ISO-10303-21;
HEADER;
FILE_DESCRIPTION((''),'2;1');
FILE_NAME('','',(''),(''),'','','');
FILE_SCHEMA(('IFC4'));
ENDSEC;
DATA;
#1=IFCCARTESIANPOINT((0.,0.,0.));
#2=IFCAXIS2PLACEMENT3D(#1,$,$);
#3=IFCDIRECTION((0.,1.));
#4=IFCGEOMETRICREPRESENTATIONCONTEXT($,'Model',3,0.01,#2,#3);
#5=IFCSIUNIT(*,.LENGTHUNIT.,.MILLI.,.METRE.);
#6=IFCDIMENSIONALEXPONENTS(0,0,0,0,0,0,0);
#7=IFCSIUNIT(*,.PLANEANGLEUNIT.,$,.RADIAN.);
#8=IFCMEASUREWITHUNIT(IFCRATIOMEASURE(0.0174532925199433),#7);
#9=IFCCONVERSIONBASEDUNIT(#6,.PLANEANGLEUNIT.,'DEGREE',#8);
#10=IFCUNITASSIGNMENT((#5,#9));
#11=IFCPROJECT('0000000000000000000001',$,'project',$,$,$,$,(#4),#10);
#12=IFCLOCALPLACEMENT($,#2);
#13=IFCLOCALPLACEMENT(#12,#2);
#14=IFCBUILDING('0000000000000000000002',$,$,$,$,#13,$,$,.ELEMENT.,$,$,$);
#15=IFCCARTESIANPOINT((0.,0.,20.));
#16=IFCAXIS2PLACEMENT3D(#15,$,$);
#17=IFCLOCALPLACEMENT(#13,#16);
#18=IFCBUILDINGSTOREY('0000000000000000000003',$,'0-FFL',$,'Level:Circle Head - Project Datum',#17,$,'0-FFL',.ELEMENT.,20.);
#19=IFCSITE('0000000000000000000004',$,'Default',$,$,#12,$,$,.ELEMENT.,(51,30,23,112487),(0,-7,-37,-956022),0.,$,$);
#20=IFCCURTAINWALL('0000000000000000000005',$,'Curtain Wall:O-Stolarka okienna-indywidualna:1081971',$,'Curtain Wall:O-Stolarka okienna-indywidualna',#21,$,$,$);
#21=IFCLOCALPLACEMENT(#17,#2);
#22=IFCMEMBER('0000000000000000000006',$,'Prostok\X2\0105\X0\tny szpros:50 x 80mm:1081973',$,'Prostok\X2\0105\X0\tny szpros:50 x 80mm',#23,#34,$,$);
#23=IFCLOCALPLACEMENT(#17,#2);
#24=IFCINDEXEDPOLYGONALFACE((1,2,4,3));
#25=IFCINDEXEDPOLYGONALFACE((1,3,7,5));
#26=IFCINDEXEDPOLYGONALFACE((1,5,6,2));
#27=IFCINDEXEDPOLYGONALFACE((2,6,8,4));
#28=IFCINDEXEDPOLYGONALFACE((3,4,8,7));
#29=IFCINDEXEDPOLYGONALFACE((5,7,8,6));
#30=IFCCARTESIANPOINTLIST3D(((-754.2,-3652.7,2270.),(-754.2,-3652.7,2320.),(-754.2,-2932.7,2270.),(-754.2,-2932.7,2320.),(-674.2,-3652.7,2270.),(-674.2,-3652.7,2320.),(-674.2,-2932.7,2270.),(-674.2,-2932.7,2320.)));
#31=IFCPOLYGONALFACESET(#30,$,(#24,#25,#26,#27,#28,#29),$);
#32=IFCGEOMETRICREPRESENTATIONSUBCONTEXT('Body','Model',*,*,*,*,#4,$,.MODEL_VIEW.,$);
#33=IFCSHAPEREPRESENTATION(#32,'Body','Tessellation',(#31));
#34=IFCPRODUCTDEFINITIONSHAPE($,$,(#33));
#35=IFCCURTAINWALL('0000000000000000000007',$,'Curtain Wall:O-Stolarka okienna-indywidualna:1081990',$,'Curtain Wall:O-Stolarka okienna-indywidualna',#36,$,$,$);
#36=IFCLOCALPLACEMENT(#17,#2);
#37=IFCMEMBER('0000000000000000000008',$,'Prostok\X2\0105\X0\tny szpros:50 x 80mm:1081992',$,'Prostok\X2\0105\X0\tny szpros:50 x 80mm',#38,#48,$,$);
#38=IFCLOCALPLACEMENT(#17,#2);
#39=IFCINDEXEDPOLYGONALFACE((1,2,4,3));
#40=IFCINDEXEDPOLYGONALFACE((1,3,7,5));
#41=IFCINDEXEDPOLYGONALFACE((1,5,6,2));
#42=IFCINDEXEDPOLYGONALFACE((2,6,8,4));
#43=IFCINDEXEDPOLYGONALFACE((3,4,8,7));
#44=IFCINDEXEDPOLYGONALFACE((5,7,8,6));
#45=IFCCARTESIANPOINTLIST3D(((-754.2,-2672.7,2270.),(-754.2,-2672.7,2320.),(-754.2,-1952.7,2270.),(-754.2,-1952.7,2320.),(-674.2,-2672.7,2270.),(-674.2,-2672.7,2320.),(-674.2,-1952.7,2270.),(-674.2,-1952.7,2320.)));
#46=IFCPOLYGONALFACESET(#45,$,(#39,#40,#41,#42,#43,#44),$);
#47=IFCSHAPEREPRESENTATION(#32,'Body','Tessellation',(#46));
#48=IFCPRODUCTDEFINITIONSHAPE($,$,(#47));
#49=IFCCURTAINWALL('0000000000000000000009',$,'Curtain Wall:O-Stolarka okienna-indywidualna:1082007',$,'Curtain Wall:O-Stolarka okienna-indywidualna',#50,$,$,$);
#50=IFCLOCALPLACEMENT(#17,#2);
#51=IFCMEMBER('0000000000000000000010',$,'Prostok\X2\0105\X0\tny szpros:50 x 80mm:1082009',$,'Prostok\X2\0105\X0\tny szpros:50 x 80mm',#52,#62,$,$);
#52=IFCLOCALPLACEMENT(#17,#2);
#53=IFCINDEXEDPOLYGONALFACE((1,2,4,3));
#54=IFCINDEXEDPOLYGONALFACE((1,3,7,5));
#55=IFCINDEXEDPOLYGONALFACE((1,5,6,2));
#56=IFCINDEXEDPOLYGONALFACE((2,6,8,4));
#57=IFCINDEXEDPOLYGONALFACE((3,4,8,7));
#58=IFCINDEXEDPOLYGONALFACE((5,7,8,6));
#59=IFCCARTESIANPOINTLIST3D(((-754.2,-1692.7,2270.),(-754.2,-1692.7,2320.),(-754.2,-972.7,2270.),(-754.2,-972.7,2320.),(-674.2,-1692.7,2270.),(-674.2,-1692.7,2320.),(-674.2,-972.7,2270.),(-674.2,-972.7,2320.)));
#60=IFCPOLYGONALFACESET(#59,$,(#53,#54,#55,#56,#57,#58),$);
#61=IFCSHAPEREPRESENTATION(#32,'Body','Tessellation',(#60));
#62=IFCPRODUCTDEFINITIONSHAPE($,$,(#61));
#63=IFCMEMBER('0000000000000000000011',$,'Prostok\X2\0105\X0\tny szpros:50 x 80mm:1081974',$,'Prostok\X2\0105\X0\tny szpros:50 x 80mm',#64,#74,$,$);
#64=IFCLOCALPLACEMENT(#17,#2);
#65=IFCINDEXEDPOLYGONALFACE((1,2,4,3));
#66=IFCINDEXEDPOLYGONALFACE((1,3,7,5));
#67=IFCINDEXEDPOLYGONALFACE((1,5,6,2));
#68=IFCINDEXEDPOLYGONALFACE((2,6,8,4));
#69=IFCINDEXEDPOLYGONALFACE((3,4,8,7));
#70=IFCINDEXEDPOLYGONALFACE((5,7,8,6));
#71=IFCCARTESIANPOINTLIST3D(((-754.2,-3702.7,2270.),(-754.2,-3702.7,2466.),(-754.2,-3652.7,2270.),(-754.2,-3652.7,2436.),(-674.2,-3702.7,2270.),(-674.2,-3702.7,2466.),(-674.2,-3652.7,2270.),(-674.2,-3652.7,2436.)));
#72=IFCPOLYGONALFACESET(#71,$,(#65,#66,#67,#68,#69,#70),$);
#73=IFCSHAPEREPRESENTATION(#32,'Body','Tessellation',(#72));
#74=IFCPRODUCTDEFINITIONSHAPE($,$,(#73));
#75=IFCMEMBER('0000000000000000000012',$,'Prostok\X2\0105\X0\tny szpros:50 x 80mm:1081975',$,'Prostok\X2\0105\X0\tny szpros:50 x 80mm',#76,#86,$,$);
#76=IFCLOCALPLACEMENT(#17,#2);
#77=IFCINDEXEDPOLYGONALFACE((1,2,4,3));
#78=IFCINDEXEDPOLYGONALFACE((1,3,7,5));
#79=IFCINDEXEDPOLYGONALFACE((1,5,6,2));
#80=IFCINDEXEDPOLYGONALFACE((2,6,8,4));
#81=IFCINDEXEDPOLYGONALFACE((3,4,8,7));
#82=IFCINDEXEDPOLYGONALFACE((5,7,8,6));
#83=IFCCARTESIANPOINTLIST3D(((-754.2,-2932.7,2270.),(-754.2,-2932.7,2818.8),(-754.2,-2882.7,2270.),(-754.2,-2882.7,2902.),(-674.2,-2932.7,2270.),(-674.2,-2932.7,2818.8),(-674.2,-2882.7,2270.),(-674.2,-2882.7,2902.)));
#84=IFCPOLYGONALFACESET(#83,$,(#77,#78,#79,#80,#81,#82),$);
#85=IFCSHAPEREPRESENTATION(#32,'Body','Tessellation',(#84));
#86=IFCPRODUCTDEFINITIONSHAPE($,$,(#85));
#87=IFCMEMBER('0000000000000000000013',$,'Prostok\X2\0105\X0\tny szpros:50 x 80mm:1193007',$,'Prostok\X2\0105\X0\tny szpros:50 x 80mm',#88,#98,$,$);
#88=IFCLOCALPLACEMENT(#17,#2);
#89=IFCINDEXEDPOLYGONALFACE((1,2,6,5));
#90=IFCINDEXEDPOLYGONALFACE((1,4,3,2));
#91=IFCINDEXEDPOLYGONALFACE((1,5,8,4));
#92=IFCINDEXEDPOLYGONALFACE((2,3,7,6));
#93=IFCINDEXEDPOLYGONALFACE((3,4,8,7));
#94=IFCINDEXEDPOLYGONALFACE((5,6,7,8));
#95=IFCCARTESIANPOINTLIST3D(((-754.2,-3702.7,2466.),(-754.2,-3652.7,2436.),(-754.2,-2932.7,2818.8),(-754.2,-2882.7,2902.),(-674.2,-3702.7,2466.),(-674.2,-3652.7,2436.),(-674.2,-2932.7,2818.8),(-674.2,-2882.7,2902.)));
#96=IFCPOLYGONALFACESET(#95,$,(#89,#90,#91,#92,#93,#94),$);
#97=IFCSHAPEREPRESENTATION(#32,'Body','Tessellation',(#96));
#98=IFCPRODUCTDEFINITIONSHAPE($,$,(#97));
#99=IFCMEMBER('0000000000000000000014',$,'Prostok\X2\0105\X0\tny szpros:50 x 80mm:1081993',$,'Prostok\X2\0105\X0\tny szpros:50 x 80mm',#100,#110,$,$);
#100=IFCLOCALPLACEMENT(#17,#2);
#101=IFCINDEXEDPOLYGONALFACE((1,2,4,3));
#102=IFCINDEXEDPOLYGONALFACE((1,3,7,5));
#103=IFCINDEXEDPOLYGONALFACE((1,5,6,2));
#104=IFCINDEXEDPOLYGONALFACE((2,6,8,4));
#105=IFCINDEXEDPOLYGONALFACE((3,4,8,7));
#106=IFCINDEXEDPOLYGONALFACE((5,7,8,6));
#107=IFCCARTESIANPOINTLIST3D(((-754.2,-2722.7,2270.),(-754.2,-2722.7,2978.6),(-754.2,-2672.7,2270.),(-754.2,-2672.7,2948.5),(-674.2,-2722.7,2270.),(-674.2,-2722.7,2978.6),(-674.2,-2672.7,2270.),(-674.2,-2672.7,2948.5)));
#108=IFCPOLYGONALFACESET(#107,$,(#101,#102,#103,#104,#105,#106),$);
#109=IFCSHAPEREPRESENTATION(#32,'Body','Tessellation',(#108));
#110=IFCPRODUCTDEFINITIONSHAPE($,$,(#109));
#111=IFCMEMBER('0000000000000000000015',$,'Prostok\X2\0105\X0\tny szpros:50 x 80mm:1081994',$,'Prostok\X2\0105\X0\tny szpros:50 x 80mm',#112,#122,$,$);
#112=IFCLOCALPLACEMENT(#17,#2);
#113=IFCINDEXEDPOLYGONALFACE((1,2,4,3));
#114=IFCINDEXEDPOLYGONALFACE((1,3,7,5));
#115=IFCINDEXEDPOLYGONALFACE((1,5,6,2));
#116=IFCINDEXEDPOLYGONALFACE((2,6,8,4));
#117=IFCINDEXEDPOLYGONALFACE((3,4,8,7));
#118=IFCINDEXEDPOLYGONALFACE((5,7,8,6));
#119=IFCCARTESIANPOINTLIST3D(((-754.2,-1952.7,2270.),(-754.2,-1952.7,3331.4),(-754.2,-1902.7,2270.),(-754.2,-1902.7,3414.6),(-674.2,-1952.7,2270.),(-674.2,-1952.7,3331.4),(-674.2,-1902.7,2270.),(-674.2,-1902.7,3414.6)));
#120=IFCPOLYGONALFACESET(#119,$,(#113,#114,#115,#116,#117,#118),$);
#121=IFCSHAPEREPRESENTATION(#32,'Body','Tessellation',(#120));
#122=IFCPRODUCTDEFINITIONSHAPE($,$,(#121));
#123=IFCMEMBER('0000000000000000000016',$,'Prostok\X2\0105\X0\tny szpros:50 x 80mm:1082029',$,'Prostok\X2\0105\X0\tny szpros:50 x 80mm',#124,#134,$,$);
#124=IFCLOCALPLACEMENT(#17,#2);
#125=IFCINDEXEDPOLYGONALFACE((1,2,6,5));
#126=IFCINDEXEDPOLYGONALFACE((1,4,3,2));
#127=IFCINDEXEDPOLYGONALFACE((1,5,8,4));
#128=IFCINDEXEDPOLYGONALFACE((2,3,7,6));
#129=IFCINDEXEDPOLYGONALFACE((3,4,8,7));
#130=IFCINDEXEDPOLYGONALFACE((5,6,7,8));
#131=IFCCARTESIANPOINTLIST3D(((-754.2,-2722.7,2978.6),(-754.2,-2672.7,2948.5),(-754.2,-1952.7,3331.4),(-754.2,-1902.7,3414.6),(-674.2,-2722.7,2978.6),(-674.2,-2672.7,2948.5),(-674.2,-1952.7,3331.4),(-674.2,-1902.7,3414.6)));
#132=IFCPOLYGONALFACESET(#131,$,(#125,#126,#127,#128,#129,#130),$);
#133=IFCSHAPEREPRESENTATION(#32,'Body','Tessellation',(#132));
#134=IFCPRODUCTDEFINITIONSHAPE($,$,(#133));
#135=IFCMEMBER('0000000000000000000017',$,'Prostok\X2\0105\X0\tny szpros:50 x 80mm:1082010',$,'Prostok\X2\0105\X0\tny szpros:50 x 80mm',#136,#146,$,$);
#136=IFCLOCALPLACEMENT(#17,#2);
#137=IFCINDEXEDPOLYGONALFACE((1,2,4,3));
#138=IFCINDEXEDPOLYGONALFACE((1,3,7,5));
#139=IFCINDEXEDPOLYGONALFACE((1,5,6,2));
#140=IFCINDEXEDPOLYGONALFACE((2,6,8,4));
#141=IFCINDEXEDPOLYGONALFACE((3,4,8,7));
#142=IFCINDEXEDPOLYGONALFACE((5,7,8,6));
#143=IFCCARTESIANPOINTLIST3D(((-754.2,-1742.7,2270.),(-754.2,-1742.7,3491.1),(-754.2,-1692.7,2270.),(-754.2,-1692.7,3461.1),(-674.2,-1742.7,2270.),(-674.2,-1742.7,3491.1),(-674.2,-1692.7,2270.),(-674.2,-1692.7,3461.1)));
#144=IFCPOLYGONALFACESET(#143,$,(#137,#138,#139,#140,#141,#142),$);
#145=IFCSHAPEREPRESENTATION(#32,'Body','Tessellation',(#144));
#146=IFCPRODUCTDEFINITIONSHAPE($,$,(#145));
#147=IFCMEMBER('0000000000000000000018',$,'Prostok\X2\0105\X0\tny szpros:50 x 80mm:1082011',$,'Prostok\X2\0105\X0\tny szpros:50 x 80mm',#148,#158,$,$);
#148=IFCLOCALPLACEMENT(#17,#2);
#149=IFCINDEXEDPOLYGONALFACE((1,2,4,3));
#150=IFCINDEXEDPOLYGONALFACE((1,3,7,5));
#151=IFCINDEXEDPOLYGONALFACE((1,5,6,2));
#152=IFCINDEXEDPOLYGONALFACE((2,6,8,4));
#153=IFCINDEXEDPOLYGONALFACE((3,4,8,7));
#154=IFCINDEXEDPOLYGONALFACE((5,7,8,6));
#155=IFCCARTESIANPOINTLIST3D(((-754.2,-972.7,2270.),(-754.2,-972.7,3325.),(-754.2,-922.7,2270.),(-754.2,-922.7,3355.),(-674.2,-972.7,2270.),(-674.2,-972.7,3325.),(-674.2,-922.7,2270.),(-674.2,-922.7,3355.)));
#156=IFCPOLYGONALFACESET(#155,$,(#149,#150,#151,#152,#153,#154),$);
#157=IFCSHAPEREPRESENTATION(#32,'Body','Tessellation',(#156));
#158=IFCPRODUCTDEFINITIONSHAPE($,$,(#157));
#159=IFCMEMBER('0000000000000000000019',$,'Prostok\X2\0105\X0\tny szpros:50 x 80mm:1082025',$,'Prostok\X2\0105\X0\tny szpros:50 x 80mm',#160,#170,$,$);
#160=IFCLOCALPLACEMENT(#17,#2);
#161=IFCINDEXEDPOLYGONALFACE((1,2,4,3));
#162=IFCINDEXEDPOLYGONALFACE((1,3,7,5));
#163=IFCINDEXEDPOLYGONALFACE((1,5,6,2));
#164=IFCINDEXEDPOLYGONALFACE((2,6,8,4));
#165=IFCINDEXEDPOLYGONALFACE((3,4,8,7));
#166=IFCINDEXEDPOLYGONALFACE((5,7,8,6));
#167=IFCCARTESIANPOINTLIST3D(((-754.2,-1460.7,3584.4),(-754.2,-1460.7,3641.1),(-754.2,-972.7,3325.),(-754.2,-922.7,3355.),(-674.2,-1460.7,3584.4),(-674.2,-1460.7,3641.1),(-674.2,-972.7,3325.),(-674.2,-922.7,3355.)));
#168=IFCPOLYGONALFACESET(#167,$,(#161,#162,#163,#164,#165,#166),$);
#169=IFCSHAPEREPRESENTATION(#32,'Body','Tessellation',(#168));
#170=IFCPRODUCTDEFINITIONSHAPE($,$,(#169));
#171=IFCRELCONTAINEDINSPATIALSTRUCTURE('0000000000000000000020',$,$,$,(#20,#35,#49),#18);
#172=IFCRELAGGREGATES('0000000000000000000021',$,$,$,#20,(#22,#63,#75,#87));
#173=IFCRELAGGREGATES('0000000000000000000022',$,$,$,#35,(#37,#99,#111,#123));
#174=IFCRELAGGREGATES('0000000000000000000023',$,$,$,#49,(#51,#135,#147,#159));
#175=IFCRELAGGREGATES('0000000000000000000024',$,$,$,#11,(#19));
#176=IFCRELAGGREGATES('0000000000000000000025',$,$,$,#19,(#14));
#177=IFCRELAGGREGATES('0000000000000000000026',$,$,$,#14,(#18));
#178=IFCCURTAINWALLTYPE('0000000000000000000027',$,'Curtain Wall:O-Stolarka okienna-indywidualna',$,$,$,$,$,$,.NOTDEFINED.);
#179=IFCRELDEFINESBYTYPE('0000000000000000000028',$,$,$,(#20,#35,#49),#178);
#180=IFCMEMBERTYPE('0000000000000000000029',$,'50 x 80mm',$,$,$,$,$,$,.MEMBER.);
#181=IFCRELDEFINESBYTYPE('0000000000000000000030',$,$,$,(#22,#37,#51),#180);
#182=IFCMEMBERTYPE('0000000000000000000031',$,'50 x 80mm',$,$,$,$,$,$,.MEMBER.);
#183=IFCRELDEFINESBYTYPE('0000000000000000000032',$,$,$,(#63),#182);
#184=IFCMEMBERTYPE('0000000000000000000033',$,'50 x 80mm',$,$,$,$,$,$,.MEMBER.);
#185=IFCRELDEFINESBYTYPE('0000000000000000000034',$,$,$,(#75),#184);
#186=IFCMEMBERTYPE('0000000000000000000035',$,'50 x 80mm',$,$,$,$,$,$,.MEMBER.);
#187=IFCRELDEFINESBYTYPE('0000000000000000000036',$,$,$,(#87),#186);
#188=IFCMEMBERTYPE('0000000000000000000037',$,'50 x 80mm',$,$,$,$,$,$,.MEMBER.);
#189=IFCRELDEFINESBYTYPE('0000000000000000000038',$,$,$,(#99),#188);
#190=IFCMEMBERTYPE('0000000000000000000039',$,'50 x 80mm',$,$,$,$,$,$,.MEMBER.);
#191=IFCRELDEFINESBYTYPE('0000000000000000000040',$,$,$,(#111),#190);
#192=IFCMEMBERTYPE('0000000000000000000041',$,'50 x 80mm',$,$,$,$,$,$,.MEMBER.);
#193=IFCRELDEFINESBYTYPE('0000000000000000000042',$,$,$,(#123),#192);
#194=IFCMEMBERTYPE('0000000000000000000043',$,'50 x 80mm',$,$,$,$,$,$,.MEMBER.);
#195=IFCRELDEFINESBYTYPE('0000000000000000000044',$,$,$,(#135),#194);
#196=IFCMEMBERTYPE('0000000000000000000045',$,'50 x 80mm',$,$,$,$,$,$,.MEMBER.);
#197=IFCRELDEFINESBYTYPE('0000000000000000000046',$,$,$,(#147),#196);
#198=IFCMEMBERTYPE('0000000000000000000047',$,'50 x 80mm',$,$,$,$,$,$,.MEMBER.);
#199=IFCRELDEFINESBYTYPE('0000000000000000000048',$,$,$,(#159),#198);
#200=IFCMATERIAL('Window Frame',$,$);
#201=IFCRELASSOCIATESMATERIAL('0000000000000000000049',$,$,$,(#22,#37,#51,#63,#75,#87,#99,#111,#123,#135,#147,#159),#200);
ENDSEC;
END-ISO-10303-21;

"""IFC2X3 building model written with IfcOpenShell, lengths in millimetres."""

from ifc_helpers import new_model, entity, si_unit, converted_unit, direction, frame, origin, origin_2d_with_axis, place, context, subcontext, project, spatial, rectangle, extrude, clip, halfspace, source, transform, mapped, material, type_object, type_shapes, element, aggregate, save


model = new_model("IFC2X3")

# Units and contexts
model_context = context("Model", 3, precision=0.01, world=origin(), true_north=direction((0.0, 1.0)))
body_context = subcontext(model_context, "Body", "Model", "MODEL_VIEW")
ifc_project = project(units=[si_unit("LENGTHUNIT", "METRE", prefix="MILLI"), converted_unit("PLANEANGLEUNIT", "DEGREE", entity("IfcRatioMeasure", 0.0174532925199433), si_unit("PLANEANGLEUNIT", "RADIAN"), dimensions=[0, 0, 0, 0, 0, 0, 0])], contexts=[model_context])

# Site, building, storey
site_placement = place(None, origin())
site = spatial("IfcSite", under=ifc_project, at=site_placement, Name="Default", CompositionType="ELEMENT", RefLatitude=(51, 30, 23, 112487), RefLongitude=(0, -7, -37, -956022), RefElevation=0.0)
building_placement = place(site_placement, origin())
building = spatial("IfcBuilding", under=site, at=building_placement, CompositionType="ELEMENT")
storey_placement = place(building_placement, frame((0.0, 0.0, 20.0)))
storey = spatial("IfcBuildingStorey", under=building, at=storey_placement, Name="0-FFL", ObjectType="Level:Circle Head - Project Datum", LongName="0-FFL", CompositionType="ELEMENT", Elevation=20.0)

# Curtain walls, members
curtain_wall_type = type_object("IfcCurtainWallType", Name="Curtain Wall:O-Stolarka okienna-indywidualna", PredefinedType="NOTDEFINED")
curtain_wall_1_placement = place(storey_placement, frame((0.0, 0.0, -20.0)))
curtain_wall_1 = element("IfcCurtainWall", 1, at=curtain_wall_1_placement, inside=storey, type_object=curtain_wall_type, Name="Curtain Wall:O-Stolarka okienna-indywidualna:1081971", ObjectType="Curtain Wall:O-Stolarka okienna-indywidualna")
ifc_material_1 = material(Name="Window Frame")
member_type_1 = type_object("IfcMemberType", Name="50 x 80mm", PredefinedType="MEMBER")
shared_shape_1 = source(origin(), body_context, "Body", "SweptSolid", [
    extrude(rectangle(XDim=80.0, YDim=50.0, at=origin_2d_with_axis()), frame((-25.0, 0.0, -720.0), z_axis=(0.0, 0.0, 1.0), x_axis=(0.0, -1.0, 0.0)), (0.0, 0.0, 1.0), 720.0),
])
type_shapes(member_type_1, [shared_shape_1])
member_1_placement = place(storey_placement, frame((-714.2, -2932.7, 2270.0), z_axis=(0.0, 1.0, 0.0), x_axis=(0.0, 0.0, -1.0)))
member_1 = element("IfcMember", 2, at=member_1_placement, type_object=member_type_1, material=ifc_material_1, Name="Prostokątny szpros:50 x 80mm:1081973", ObjectType="Prostokątny szpros:50 x 80mm", context=body_context, shape_type="MappedRepresentation", body=[
    mapped(shared_shape_1, transform((0.0, 0.0, 0.0), scale=1.0)),
])
curtain_wall_2_placement = place(storey_placement, frame((0.0, 0.0, -20.0)))
curtain_wall_2 = element("IfcCurtainWall", 3, at=curtain_wall_2_placement, inside=storey, type_object=curtain_wall_type, Name="Curtain Wall:O-Stolarka okienna-indywidualna:1081990", ObjectType="Curtain Wall:O-Stolarka okienna-indywidualna")
member_2_placement = place(storey_placement, frame((-714.2, -1952.7, 2270.0), z_axis=(0.0, 1.0, 0.0), x_axis=(0.0, 0.0, -1.0)))
member_2 = element("IfcMember", 4, at=member_2_placement, type_object=member_type_1, material=ifc_material_1, Name="Prostokątny szpros:50 x 80mm:1081992", ObjectType="Prostokątny szpros:50 x 80mm", context=body_context, shape_type="MappedRepresentation", body=[
    mapped(shared_shape_1, transform((0.0, 0.0, 0.0), scale=1.0)),
])
curtain_wall_3_placement = place(storey_placement, frame((0.0, 0.0, -20.0)))
curtain_wall_3 = element("IfcCurtainWall", 5, at=curtain_wall_3_placement, inside=storey, type_object=curtain_wall_type, Name="Curtain Wall:O-Stolarka okienna-indywidualna:1082007", ObjectType="Curtain Wall:O-Stolarka okienna-indywidualna")
member_3_placement = place(storey_placement, frame((-714.2, -972.7, 2270.0), z_axis=(0.0, 1.0, 0.0), x_axis=(0.0, 0.0, -1.0)))
member_3 = element("IfcMember", 6, at=member_3_placement, type_object=member_type_1, material=ifc_material_1, Name="Prostokątny szpros:50 x 80mm:1082009", ObjectType="Prostokątny szpros:50 x 80mm", context=body_context, shape_type="MappedRepresentation", body=[
    mapped(shared_shape_1, transform((0.0, 0.0, 0.0), scale=1.0)),
])

# Members
member_type_2 = type_object("IfcMemberType", Name="50 x 80mm", PredefinedType="MEMBER")
shared_shape_2 = source(origin(), body_context, "Body", "Clipping", [
    clip(extrude(rectangle(XDim=80.0, YDim=50.0, at=origin_2d_with_axis()), frame((-25.0, 0.0, -196.0), z_axis=(0.0, 0.0, 1.0), x_axis=(0.0, -1.0, 0.0)), (0.0, 0.0, 1.0), 196.0), halfspace(frame((0.0, -304.8, -196.0), z_axis=(-0.515038, 0.0, -0.857167), x_axis=(-0.857167, 0.0, 0.515038)), False)),
])
type_shapes(member_type_2, [shared_shape_2])
member_4_placement = place(storey_placement, frame((-714.2, -3702.7, 2270.0), z_axis=(0.0, 0.0, -1.0), x_axis=(0.0, -1.0, 0.0)))
member_4 = element("IfcMember", 7, at=member_4_placement, type_object=member_type_2, material=ifc_material_1, Name="Prostokątny szpros:50 x 80mm:1081974", ObjectType="Prostokątny szpros:50 x 80mm", context=body_context, shape_type="MappedRepresentation", body=[
    mapped(shared_shape_2, transform((0.0, 0.0, 0.0), scale=1.0)),
])
member_type_3 = type_object("IfcMemberType", Name="50 x 80mm", PredefinedType="MEMBER")
shared_shape_3 = source(origin(), body_context, "Body", "Clipping", [
    clip(extrude(rectangle(XDim=80.0, YDim=50.0, at=origin_2d_with_axis()), frame((-25.0, 0.0, -632.0), z_axis=(0.0, 0.0, 1.0), x_axis=(0.0, -1.0, 0.0)), (0.0, 0.0, 1.0), 632.0), halfspace(frame((0.0, -304.8, 0.0), z_axis=(-0.857167, 0.0, 0.515038), x_axis=(-0.515038, 0.0, -0.857167)), False)),
])
type_shapes(member_type_3, [shared_shape_3])
member_5_placement = place(storey_placement, frame((-714.2, -2882.7, 2902.0), z_axis=(0.0, 0.0, 1.0), x_axis=(0.0, 1.0, 0.0)))
member_5 = element("IfcMember", 8, at=member_5_placement, type_object=member_type_3, material=ifc_material_1, Name="Prostokątny szpros:50 x 80mm:1081975", ObjectType="Prostokątny szpros:50 x 80mm", context=body_context, shape_type="MappedRepresentation", body=[
    mapped(shared_shape_3, transform((0.0, 0.0, 0.0), scale=1.0)),
])
member_type_4 = type_object("IfcMemberType", Name="50 x 80mm", PredefinedType="MEMBER")
shared_shape_4 = source(origin(), body_context, "Body", "Clipping", [
    clip(clip(extrude(rectangle(XDim=80.0, YDim=50.0, at=origin_2d_with_axis()), frame((-25.0, 0.0, -928.7), z_axis=(0.0, 0.0, 1.0), x_axis=(0.0, -1.0, 0.0)), (0.0, 0.0, 1.0), 928.7), halfspace(frame((0.0, -304.8, -928.7), z_axis=(-0.857167, 0.0, -0.515038), x_axis=(-0.515038, 0.0, 0.857167)), False)), halfspace(frame((0.0, -304.8, 0.0), z_axis=(-0.515038, 0.0, 0.857167), x_axis=(-0.857167, 0.0, -0.515038)), False)),
])
type_shapes(member_type_4, [shared_shape_4])
member_6_placement = place(storey_placement, frame((-714.2, -3702.7, 2466.0), z_axis=(0.0, -0.882948, -0.469472), x_axis=(0.0, -0.469472, 0.882948)))
member_6 = element("IfcMember", 9, at=member_6_placement, type_object=member_type_4, material=ifc_material_1, Name="Prostokątny szpros:50 x 80mm:1193007", ObjectType="Prostokątny szpros:50 x 80mm", context=body_context, shape_type="MappedRepresentation", body=[
    mapped(shared_shape_4, transform((0.0, 0.0, 0.0), scale=1.0)),
])
member_type_5 = type_object("IfcMemberType", Name="50 x 80mm", PredefinedType="MEMBER")
shared_shape_5 = source(origin(), body_context, "Body", "Clipping", [
    clip(extrude(rectangle(XDim=80.0, YDim=50.0, at=origin_2d_with_axis()), frame((-25.0, 0.0, -708.6), z_axis=(0.0, 0.0, 1.0), x_axis=(0.0, -1.0, 0.0)), (0.0, 0.0, 1.0), 708.6), halfspace(frame((0.0, -304.8, -708.6), z_axis=(-0.515038, 0.0, -0.857167), x_axis=(-0.857167, 0.0, 0.515038)), False)),
])
type_shapes(member_type_5, [shared_shape_5])
member_7_placement = place(storey_placement, frame((-714.2, -2722.7, 2270.0), z_axis=(0.0, 0.0, -1.0), x_axis=(0.0, -1.0, 0.0)))
member_7 = element("IfcMember", 10, at=member_7_placement, type_object=member_type_5, material=ifc_material_1, Name="Prostokątny szpros:50 x 80mm:1081993", ObjectType="Prostokątny szpros:50 x 80mm", context=body_context, shape_type="MappedRepresentation", body=[
    mapped(shared_shape_5, transform((0.0, 0.0, 0.0), scale=1.0)),
])
member_type_6 = type_object("IfcMemberType", Name="50 x 80mm", PredefinedType="MEMBER")
shared_shape_6 = source(origin(), body_context, "Body", "Clipping", [
    clip(extrude(rectangle(XDim=80.0, YDim=50.0, at=origin_2d_with_axis()), frame((-25.0, 0.0, -1144.6), z_axis=(0.0, 0.0, 1.0), x_axis=(0.0, -1.0, 0.0)), (0.0, 0.0, 1.0), 1144.6), halfspace(frame((0.0, -304.8, 0.0), z_axis=(-0.857167, 0.0, 0.515038), x_axis=(-0.515038, 0.0, -0.857167)), False)),
])
type_shapes(member_type_6, [shared_shape_6])
member_8_placement = place(storey_placement, frame((-714.2, -1902.7, 3414.6), z_axis=(0.0, 0.0, 1.0), x_axis=(0.0, 1.0, 0.0)))
member_8 = element("IfcMember", 11, at=member_8_placement, type_object=member_type_6, material=ifc_material_1, Name="Prostokątny szpros:50 x 80mm:1081994", ObjectType="Prostokątny szpros:50 x 80mm", context=body_context, shape_type="MappedRepresentation", body=[
    mapped(shared_shape_6, transform((0.0, 0.0, 0.0), scale=1.0)),
])
member_type_7 = type_object("IfcMemberType", Name="50 x 80mm", PredefinedType="MEMBER")
shared_shape_7 = source(origin(), body_context, "Body", "Clipping", [
    clip(clip(extrude(rectangle(XDim=80.0, YDim=50.0, at=origin_2d_with_axis()), frame((-25.0, 0.0, -928.7), z_axis=(0.0, 0.0, 1.0), x_axis=(0.0, -1.0, 0.0)), (0.0, 0.0, 1.0), 928.7), halfspace(frame((0.0, -304.8, -928.7), z_axis=(-0.857167, 0.0, -0.515038), x_axis=(-0.515038, 0.0, 0.857167)), False)), halfspace(frame((0.0, -304.8, 0.0), z_axis=(-0.515038, 0.0, 0.857167), x_axis=(-0.857167, 0.0, -0.515038)), False)),
])
type_shapes(member_type_7, [shared_shape_7])
member_9_placement = place(storey_placement, frame((-714.2, -2722.7, 2978.6), z_axis=(0.0, -0.882948, -0.469472), x_axis=(0.0, -0.469472, 0.882948)))
member_9 = element("IfcMember", 12, at=member_9_placement, type_object=member_type_7, material=ifc_material_1, Name="Prostokątny szpros:50 x 80mm:1082029", ObjectType="Prostokątny szpros:50 x 80mm", context=body_context, shape_type="MappedRepresentation", body=[
    mapped(shared_shape_7, transform((0.0, 0.0, 0.0), scale=1.0)),
])
member_type_8 = type_object("IfcMemberType", Name="50 x 80mm", PredefinedType="MEMBER")
shared_shape_8 = source(origin(), body_context, "Body", "Clipping", [
    clip(extrude(rectangle(XDim=80.0, YDim=50.0, at=origin_2d_with_axis()), frame((-25.0, 0.0, -1221.1), z_axis=(0.0, 0.0, 1.0), x_axis=(0.0, -1.0, 0.0)), (0.0, 0.0, 1.0), 1221.1), halfspace(frame((0.0, -304.8, -1221.1), z_axis=(-0.515038, 0.0, -0.857167), x_axis=(-0.857167, 0.0, 0.515038)), False)),
])
type_shapes(member_type_8, [shared_shape_8])
member_10_placement = place(storey_placement, frame((-714.2, -1742.7, 2270.0), z_axis=(0.0, 0.0, -1.0), x_axis=(0.0, -1.0, 0.0)))
member_10 = element("IfcMember", 13, at=member_10_placement, type_object=member_type_8, material=ifc_material_1, Name="Prostokątny szpros:50 x 80mm:1082010", ObjectType="Prostokątny szpros:50 x 80mm", context=body_context, shape_type="MappedRepresentation", body=[
    mapped(shared_shape_8, transform((0.0, 0.0, 0.0), scale=1.0)),
])
member_type_9 = type_object("IfcMemberType", Name="50 x 80mm", PredefinedType="MEMBER")
shared_shape_9 = source(origin(), body_context, "Body", "Clipping", [
    clip(extrude(rectangle(XDim=80.0, YDim=50.0, at=origin_2d_with_axis()), frame((-25.0, 0.0, -1085.0), z_axis=(0.0, 0.0, 1.0), x_axis=(0.0, -1.0, 0.0)), (0.0, 0.0, 1.0), 1085.0), halfspace(frame((0.0, -304.8, 0.0), z_axis=(-0.515039, 0.0, 0.857167), x_axis=(-0.857167, 0.0, -0.515039)), False)),
])
type_shapes(member_type_9, [shared_shape_9])
member_11_placement = place(storey_placement, frame((-714.2, -922.7, 3355.0), z_axis=(0.0, 0.0, 1.0), x_axis=(0.0, 1.0, 0.0)))
member_11 = element("IfcMember", 14, at=member_11_placement, type_object=member_type_9, material=ifc_material_1, Name="Prostokątny szpros:50 x 80mm:1082011", ObjectType="Prostokątny szpros:50 x 80mm", context=body_context, shape_type="MappedRepresentation", body=[
    mapped(shared_shape_9, transform((0.0, 0.0, 0.0), scale=1.0)),
])
member_type_10 = type_object("IfcMemberType", Name="50 x 80mm", PredefinedType="MEMBER")
shared_shape_10 = source(origin(), body_context, "Body", "Clipping", [
    clip(clip(extrude(rectangle(XDim=80.0, YDim=50.0, at=origin_2d_with_axis()), frame((-25.0, 0.0, -609.3), z_axis=(0.0, 0.0, 1.0), x_axis=(0.0, -1.0, 0.0)), (0.0, 0.0, 1.0), 609.3), halfspace(frame((0.0, -304.8, -609.3), z_axis=(-0.515039, 0.0, -0.857167), x_axis=(-0.857167, 0.0, 0.515039)), False)), halfspace(frame((0.0, -304.8, 0.0), z_axis=(-0.469471, 0.0, 0.882948), x_axis=(-0.882948, 0.0, -0.469471)), False)),
])
type_shapes(member_type_10, [shared_shape_10])
member_12_placement = place(storey_placement, frame((-714.2, -1460.7, 3641.1), z_axis=(0.0, -0.882948, 0.46947), x_axis=(0.0, 0.46947, 0.882948)))
member_12 = element("IfcMember", 15, at=member_12_placement, type_object=member_type_10, material=ifc_material_1, Name="Prostokątny szpros:50 x 80mm:1082025", ObjectType="Prostokątny szpros:50 x 80mm", context=body_context, shape_type="MappedRepresentation", body=[
    mapped(shared_shape_10, transform((0.0, 0.0, 0.0), scale=1.0)),
])

aggregate(curtain_wall_1, [member_1, member_4, member_5, member_6])
aggregate(curtain_wall_2, [member_2, member_7, member_8, member_9])
aggregate(curtain_wall_3, [member_3, member_10, member_11, member_12])

save(model, "model.ifc")
